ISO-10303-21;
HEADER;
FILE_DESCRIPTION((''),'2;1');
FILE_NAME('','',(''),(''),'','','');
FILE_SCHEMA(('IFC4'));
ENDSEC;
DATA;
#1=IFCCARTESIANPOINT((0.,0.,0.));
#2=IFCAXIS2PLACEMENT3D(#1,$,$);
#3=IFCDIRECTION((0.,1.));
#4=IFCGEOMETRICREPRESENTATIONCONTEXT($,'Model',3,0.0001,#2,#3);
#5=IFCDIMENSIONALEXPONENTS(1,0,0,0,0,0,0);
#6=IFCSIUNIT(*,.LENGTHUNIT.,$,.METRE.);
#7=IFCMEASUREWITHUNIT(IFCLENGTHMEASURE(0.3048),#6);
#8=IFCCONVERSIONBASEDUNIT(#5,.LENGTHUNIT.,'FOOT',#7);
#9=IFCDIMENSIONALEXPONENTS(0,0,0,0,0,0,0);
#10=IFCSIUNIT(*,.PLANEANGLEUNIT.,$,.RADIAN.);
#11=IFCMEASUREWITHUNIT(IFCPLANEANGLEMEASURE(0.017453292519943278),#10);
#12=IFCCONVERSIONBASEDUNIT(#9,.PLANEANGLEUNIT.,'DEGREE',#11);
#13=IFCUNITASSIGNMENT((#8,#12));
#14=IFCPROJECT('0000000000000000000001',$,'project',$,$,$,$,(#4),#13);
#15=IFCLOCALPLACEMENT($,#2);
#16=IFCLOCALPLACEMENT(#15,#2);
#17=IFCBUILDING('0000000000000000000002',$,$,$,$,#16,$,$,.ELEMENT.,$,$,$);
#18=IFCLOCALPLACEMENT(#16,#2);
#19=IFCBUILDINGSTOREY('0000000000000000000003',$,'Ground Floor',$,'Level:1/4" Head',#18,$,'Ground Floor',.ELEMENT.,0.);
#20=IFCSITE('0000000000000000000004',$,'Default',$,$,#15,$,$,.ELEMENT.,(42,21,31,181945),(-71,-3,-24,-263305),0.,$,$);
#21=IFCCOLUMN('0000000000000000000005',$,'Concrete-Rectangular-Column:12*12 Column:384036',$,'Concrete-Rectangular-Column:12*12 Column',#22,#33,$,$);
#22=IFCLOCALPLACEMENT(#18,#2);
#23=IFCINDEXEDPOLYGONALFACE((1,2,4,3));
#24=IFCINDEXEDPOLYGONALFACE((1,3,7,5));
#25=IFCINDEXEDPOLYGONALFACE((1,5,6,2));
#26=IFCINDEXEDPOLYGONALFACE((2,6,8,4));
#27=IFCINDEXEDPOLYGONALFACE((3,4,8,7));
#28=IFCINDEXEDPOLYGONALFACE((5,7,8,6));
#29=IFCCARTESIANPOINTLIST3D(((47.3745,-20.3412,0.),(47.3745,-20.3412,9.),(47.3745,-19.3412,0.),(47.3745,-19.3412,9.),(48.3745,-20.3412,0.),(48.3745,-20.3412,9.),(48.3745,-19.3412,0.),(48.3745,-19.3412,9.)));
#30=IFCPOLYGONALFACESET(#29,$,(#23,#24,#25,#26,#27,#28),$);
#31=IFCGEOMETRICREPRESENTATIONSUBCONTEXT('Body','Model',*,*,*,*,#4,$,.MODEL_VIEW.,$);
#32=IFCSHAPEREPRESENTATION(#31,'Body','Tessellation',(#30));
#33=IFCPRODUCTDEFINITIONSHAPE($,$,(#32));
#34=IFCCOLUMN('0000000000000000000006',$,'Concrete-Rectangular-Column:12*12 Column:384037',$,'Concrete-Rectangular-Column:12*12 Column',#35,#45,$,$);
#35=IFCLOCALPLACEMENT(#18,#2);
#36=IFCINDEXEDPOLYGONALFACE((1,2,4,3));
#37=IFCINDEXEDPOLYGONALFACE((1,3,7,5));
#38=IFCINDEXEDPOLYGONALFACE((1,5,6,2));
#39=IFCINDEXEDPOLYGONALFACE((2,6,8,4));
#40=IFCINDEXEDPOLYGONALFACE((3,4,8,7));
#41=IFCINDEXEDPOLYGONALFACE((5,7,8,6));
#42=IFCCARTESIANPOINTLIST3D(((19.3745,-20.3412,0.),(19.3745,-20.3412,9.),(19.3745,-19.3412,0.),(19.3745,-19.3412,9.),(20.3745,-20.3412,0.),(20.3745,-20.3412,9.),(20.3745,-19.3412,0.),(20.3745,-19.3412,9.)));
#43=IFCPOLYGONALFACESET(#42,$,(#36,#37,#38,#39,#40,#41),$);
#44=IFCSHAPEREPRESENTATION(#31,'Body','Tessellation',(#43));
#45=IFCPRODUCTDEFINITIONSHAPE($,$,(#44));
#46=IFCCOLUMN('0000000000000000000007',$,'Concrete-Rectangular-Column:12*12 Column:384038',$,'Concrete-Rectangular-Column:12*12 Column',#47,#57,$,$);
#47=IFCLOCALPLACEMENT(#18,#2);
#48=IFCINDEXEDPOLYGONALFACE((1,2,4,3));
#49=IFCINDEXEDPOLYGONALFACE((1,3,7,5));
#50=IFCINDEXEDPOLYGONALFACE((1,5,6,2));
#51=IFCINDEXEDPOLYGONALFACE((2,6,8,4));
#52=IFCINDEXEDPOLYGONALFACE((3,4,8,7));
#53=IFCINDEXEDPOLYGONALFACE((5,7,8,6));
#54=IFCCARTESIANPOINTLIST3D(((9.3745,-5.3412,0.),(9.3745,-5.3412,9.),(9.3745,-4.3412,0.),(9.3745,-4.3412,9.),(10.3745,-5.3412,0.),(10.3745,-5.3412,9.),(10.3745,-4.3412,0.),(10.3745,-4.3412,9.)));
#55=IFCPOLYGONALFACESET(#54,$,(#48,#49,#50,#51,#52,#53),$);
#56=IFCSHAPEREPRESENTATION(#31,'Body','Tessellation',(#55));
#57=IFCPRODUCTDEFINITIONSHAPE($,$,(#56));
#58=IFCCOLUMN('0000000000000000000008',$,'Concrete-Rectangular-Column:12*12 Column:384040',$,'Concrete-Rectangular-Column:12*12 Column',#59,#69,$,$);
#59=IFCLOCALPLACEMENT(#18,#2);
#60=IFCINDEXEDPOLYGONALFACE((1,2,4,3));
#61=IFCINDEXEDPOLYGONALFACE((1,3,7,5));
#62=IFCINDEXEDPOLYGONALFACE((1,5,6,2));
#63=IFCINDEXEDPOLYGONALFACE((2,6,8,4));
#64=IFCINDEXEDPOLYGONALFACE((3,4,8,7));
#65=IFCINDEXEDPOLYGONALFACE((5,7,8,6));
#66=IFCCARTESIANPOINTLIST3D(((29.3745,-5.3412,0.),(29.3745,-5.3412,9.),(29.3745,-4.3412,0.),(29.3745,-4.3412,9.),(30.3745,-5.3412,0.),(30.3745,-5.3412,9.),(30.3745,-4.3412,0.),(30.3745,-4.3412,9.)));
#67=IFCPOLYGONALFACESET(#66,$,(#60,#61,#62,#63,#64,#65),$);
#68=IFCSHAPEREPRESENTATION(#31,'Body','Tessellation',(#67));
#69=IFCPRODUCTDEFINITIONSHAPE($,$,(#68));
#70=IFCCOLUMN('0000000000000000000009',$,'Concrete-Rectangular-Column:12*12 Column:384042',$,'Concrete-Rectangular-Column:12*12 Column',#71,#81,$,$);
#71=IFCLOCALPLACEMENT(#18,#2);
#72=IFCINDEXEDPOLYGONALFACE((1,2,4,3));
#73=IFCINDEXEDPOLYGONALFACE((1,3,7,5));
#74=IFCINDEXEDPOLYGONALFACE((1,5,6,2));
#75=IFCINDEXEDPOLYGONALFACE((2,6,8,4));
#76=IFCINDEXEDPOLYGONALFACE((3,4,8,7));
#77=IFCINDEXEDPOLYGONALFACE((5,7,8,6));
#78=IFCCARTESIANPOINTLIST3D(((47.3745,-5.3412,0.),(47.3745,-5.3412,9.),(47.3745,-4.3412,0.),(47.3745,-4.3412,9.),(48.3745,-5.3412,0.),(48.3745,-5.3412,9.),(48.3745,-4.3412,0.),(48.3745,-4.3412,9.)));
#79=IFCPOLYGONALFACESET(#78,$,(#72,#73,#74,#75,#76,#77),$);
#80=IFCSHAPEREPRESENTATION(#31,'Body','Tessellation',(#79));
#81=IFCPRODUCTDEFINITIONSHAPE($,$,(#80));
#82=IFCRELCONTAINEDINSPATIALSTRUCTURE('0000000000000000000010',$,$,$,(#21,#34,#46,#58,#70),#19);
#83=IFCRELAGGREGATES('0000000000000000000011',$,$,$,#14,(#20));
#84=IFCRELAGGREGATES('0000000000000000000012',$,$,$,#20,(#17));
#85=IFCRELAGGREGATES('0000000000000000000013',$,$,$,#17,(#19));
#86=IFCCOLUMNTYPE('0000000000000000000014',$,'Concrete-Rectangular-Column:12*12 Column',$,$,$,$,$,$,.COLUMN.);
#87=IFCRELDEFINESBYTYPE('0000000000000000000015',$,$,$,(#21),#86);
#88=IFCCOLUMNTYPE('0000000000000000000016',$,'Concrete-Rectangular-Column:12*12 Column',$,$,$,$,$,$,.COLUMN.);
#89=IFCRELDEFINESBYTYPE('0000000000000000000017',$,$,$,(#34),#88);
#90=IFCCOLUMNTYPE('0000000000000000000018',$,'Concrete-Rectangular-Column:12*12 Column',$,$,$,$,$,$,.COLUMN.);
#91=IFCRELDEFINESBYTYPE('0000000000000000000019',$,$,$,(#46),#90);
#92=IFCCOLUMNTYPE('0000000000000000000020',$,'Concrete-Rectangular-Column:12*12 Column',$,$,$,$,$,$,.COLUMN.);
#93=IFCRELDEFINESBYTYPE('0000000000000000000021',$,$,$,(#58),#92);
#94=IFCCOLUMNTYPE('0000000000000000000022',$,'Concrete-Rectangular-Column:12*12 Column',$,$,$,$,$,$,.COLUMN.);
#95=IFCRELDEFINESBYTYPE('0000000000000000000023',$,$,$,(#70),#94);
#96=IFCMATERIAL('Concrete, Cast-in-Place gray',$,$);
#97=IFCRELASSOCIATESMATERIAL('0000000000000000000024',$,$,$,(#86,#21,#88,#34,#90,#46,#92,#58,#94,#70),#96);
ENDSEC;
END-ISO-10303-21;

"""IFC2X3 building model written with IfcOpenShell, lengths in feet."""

from ifc_helpers import new_model, entity, si_unit, converted_unit, direction, frame, frame_2d, origin, origin_2d_with_axis, place, context, subcontext, project, spatial, rectangle, extrude, source, transform, mapped, material, type_object, type_shapes, element, save


model = new_model("IFC2X3")

# Units and contexts
model_context = context("Model", 3, precision=0.0001, world=origin(), true_north=direction((0.0, 1.0)))
body_context = subcontext(model_context, "Body", "Model", "MODEL_VIEW")
ifc_project = project(units=[converted_unit("LENGTHUNIT", "FOOT", entity("IfcLengthMeasure", 0.3048), si_unit("LENGTHUNIT", "METRE"), dimensions=[1, 0, 0, 0, 0, 0, 0]), converted_unit("PLANEANGLEUNIT", "DEGREE", entity("IfcPlaneAngleMeasure", 0.017453292519943278), si_unit("PLANEANGLEUNIT", "RADIAN"), dimensions=[0, 0, 0, 0, 0, 0, 0])], contexts=[model_context])

# Site, building, storey
site_placement = place(None, origin())
site = spatial("IfcSite", under=ifc_project, at=site_placement, Name="Default", CompositionType="ELEMENT", RefLatitude=(42, 21, 31, 181945), RefLongitude=(-71, -3, -24, -263305), RefElevation=0.0)
building_placement = place(site_placement, origin())
building = spatial("IfcBuilding", under=site, at=building_placement, CompositionType="ELEMENT")
storey_placement = place(building_placement, origin())
storey = spatial("IfcBuildingStorey", under=building, at=storey_placement, Name="Ground Floor", ObjectType="Level:1/4\" Head", LongName="Ground Floor", CompositionType="ELEMENT", Elevation=0.0)

# Columns
ifc_material = material(Name="Concrete, Cast-in-Place gray")
column_type_1 = type_object("IfcColumnType", Name="Concrete-Rectangular-Column:12*12 Column", PredefinedType="COLUMN", material=ifc_material)
shared_shape_1 = source(origin(), body_context, "Body", "SweptSolid", [
    extrude(rectangle(XDim=1.0, YDim=1.0, at=frame_2d((0.0, 0.0), x_axis=(1.0, 0.0))), frame((47.8745, -19.8412, 0.0), z_axis=(0.0, 0.0, 1.0), x_axis=(-1.0, 0.0, 0.0)), (0.0, 0.0, 1.0), 9.0),
])
type_shapes(column_type_1, [shared_shape_1])
column_1_placement = place(storey_placement, origin())
element("IfcColumn", 1, at=column_1_placement, inside=storey, type_object=column_type_1, material=ifc_material, Name="Concrete-Rectangular-Column:12*12 Column:384036", ObjectType="Concrete-Rectangular-Column:12*12 Column", context=body_context, shape_type="MappedRepresentation", body=[
    mapped(shared_shape_1, transform((0.0, 0.0, 0.0), scale=1.0)),
])
column_type_2 = type_object("IfcColumnType", Name="Concrete-Rectangular-Column:12*12 Column", PredefinedType="COLUMN", material=ifc_material)
shared_shape_2 = source(origin(), body_context, "Body", "SweptSolid", [
    extrude(rectangle(XDim=1.0, YDim=1.0, at=frame_2d((0.0, 0.0), x_axis=(1.0, 0.0))), frame((19.8745, -19.8412, 0.0), z_axis=(0.0, 0.0, 1.0), x_axis=(-1.0, 0.0, 0.0)), (0.0, 0.0, 1.0), 9.0),
])
type_shapes(column_type_2, [shared_shape_2])
column_2_placement = place(storey_placement, origin())
element("IfcColumn", 2, at=column_2_placement, inside=storey, type_object=column_type_2, material=ifc_material, Name="Concrete-Rectangular-Column:12*12 Column:384037", ObjectType="Concrete-Rectangular-Column:12*12 Column", context=body_context, shape_type="MappedRepresentation", body=[
    mapped(shared_shape_2, transform((0.0, 0.0, 0.0), scale=1.0)),
])
column_type_3 = type_object("IfcColumnType", Name="Concrete-Rectangular-Column:12*12 Column", PredefinedType="COLUMN", material=ifc_material)
shared_shape_3 = source(origin(), body_context, "Body", "SweptSolid", [
    extrude(rectangle(XDim=1.0, YDim=1.0, at=origin_2d_with_axis()), frame((9.8745, -4.8412, 0.0), z_axis=(0.0, 0.0, 1.0), x_axis=(-1.0, 0.0, 0.0)), (0.0, 0.0, 1.0), 9.0),
])
type_shapes(column_type_3, [shared_shape_3])
column_3_placement = place(storey_placement, origin())
element("IfcColumn", 3, at=column_3_placement, inside=storey, type_object=column_type_3, material=ifc_material, Name="Concrete-Rectangular-Column:12*12 Column:384038", ObjectType="Concrete-Rectangular-Column:12*12 Column", context=body_context, shape_type="MappedRepresentation", body=[
    mapped(shared_shape_3, transform((0.0, 0.0, 0.0), scale=1.0)),
])
column_type_4 = type_object("IfcColumnType", Name="Concrete-Rectangular-Column:12*12 Column", PredefinedType="COLUMN", material=ifc_material)
shared_shape_4 = source(origin(), body_context, "Body", "SweptSolid", [
    extrude(rectangle(XDim=1.0, YDim=1.0, at=frame_2d((0.0, 0.0), x_axis=(1.0, 0.0))), frame((29.8745, -4.8412, 0.0), z_axis=(0.0, 0.0, 1.0), x_axis=(-1.0, 0.0, 0.0)), (0.0, 0.0, 1.0), 9.0),
])
type_shapes(column_type_4, [shared_shape_4])
column_4_placement = place(storey_placement, origin())
element("IfcColumn", 4, at=column_4_placement, inside=storey, type_object=column_type_4, material=ifc_material, Name="Concrete-Rectangular-Column:12*12 Column:384040", ObjectType="Concrete-Rectangular-Column:12*12 Column", context=body_context, shape_type="MappedRepresentation", body=[
    mapped(shared_shape_4, transform((0.0, 0.0, 0.0), scale=1.0)),
])
column_type_5 = type_object("IfcColumnType", Name="Concrete-Rectangular-Column:12*12 Column", PredefinedType="COLUMN", material=ifc_material)
shared_shape_5 = source(origin(), body_context, "Body", "SweptSolid", [
    extrude(rectangle(XDim=1.0, YDim=1.0, at=frame_2d((0.0, 0.0), x_axis=(1.0, 0.0))), frame((47.8745, -4.8412, 0.0), z_axis=(0.0, 0.0, 1.0), x_axis=(-1.0, 0.0, 0.0)), (0.0, 0.0, 1.0), 9.0),
])
type_shapes(column_type_5, [shared_shape_5])
column_5_placement = place(storey_placement, origin())
element("IfcColumn", 5, at=column_5_placement, inside=storey, type_object=column_type_5, material=ifc_material, Name="Concrete-Rectangular-Column:12*12 Column:384042", ObjectType="Concrete-Rectangular-Column:12*12 Column", context=body_context, shape_type="MappedRepresentation", body=[
    mapped(shared_shape_5, transform((0.0, 0.0, 0.0), scale=1.0)),
])

save(model, "model.ifc")
